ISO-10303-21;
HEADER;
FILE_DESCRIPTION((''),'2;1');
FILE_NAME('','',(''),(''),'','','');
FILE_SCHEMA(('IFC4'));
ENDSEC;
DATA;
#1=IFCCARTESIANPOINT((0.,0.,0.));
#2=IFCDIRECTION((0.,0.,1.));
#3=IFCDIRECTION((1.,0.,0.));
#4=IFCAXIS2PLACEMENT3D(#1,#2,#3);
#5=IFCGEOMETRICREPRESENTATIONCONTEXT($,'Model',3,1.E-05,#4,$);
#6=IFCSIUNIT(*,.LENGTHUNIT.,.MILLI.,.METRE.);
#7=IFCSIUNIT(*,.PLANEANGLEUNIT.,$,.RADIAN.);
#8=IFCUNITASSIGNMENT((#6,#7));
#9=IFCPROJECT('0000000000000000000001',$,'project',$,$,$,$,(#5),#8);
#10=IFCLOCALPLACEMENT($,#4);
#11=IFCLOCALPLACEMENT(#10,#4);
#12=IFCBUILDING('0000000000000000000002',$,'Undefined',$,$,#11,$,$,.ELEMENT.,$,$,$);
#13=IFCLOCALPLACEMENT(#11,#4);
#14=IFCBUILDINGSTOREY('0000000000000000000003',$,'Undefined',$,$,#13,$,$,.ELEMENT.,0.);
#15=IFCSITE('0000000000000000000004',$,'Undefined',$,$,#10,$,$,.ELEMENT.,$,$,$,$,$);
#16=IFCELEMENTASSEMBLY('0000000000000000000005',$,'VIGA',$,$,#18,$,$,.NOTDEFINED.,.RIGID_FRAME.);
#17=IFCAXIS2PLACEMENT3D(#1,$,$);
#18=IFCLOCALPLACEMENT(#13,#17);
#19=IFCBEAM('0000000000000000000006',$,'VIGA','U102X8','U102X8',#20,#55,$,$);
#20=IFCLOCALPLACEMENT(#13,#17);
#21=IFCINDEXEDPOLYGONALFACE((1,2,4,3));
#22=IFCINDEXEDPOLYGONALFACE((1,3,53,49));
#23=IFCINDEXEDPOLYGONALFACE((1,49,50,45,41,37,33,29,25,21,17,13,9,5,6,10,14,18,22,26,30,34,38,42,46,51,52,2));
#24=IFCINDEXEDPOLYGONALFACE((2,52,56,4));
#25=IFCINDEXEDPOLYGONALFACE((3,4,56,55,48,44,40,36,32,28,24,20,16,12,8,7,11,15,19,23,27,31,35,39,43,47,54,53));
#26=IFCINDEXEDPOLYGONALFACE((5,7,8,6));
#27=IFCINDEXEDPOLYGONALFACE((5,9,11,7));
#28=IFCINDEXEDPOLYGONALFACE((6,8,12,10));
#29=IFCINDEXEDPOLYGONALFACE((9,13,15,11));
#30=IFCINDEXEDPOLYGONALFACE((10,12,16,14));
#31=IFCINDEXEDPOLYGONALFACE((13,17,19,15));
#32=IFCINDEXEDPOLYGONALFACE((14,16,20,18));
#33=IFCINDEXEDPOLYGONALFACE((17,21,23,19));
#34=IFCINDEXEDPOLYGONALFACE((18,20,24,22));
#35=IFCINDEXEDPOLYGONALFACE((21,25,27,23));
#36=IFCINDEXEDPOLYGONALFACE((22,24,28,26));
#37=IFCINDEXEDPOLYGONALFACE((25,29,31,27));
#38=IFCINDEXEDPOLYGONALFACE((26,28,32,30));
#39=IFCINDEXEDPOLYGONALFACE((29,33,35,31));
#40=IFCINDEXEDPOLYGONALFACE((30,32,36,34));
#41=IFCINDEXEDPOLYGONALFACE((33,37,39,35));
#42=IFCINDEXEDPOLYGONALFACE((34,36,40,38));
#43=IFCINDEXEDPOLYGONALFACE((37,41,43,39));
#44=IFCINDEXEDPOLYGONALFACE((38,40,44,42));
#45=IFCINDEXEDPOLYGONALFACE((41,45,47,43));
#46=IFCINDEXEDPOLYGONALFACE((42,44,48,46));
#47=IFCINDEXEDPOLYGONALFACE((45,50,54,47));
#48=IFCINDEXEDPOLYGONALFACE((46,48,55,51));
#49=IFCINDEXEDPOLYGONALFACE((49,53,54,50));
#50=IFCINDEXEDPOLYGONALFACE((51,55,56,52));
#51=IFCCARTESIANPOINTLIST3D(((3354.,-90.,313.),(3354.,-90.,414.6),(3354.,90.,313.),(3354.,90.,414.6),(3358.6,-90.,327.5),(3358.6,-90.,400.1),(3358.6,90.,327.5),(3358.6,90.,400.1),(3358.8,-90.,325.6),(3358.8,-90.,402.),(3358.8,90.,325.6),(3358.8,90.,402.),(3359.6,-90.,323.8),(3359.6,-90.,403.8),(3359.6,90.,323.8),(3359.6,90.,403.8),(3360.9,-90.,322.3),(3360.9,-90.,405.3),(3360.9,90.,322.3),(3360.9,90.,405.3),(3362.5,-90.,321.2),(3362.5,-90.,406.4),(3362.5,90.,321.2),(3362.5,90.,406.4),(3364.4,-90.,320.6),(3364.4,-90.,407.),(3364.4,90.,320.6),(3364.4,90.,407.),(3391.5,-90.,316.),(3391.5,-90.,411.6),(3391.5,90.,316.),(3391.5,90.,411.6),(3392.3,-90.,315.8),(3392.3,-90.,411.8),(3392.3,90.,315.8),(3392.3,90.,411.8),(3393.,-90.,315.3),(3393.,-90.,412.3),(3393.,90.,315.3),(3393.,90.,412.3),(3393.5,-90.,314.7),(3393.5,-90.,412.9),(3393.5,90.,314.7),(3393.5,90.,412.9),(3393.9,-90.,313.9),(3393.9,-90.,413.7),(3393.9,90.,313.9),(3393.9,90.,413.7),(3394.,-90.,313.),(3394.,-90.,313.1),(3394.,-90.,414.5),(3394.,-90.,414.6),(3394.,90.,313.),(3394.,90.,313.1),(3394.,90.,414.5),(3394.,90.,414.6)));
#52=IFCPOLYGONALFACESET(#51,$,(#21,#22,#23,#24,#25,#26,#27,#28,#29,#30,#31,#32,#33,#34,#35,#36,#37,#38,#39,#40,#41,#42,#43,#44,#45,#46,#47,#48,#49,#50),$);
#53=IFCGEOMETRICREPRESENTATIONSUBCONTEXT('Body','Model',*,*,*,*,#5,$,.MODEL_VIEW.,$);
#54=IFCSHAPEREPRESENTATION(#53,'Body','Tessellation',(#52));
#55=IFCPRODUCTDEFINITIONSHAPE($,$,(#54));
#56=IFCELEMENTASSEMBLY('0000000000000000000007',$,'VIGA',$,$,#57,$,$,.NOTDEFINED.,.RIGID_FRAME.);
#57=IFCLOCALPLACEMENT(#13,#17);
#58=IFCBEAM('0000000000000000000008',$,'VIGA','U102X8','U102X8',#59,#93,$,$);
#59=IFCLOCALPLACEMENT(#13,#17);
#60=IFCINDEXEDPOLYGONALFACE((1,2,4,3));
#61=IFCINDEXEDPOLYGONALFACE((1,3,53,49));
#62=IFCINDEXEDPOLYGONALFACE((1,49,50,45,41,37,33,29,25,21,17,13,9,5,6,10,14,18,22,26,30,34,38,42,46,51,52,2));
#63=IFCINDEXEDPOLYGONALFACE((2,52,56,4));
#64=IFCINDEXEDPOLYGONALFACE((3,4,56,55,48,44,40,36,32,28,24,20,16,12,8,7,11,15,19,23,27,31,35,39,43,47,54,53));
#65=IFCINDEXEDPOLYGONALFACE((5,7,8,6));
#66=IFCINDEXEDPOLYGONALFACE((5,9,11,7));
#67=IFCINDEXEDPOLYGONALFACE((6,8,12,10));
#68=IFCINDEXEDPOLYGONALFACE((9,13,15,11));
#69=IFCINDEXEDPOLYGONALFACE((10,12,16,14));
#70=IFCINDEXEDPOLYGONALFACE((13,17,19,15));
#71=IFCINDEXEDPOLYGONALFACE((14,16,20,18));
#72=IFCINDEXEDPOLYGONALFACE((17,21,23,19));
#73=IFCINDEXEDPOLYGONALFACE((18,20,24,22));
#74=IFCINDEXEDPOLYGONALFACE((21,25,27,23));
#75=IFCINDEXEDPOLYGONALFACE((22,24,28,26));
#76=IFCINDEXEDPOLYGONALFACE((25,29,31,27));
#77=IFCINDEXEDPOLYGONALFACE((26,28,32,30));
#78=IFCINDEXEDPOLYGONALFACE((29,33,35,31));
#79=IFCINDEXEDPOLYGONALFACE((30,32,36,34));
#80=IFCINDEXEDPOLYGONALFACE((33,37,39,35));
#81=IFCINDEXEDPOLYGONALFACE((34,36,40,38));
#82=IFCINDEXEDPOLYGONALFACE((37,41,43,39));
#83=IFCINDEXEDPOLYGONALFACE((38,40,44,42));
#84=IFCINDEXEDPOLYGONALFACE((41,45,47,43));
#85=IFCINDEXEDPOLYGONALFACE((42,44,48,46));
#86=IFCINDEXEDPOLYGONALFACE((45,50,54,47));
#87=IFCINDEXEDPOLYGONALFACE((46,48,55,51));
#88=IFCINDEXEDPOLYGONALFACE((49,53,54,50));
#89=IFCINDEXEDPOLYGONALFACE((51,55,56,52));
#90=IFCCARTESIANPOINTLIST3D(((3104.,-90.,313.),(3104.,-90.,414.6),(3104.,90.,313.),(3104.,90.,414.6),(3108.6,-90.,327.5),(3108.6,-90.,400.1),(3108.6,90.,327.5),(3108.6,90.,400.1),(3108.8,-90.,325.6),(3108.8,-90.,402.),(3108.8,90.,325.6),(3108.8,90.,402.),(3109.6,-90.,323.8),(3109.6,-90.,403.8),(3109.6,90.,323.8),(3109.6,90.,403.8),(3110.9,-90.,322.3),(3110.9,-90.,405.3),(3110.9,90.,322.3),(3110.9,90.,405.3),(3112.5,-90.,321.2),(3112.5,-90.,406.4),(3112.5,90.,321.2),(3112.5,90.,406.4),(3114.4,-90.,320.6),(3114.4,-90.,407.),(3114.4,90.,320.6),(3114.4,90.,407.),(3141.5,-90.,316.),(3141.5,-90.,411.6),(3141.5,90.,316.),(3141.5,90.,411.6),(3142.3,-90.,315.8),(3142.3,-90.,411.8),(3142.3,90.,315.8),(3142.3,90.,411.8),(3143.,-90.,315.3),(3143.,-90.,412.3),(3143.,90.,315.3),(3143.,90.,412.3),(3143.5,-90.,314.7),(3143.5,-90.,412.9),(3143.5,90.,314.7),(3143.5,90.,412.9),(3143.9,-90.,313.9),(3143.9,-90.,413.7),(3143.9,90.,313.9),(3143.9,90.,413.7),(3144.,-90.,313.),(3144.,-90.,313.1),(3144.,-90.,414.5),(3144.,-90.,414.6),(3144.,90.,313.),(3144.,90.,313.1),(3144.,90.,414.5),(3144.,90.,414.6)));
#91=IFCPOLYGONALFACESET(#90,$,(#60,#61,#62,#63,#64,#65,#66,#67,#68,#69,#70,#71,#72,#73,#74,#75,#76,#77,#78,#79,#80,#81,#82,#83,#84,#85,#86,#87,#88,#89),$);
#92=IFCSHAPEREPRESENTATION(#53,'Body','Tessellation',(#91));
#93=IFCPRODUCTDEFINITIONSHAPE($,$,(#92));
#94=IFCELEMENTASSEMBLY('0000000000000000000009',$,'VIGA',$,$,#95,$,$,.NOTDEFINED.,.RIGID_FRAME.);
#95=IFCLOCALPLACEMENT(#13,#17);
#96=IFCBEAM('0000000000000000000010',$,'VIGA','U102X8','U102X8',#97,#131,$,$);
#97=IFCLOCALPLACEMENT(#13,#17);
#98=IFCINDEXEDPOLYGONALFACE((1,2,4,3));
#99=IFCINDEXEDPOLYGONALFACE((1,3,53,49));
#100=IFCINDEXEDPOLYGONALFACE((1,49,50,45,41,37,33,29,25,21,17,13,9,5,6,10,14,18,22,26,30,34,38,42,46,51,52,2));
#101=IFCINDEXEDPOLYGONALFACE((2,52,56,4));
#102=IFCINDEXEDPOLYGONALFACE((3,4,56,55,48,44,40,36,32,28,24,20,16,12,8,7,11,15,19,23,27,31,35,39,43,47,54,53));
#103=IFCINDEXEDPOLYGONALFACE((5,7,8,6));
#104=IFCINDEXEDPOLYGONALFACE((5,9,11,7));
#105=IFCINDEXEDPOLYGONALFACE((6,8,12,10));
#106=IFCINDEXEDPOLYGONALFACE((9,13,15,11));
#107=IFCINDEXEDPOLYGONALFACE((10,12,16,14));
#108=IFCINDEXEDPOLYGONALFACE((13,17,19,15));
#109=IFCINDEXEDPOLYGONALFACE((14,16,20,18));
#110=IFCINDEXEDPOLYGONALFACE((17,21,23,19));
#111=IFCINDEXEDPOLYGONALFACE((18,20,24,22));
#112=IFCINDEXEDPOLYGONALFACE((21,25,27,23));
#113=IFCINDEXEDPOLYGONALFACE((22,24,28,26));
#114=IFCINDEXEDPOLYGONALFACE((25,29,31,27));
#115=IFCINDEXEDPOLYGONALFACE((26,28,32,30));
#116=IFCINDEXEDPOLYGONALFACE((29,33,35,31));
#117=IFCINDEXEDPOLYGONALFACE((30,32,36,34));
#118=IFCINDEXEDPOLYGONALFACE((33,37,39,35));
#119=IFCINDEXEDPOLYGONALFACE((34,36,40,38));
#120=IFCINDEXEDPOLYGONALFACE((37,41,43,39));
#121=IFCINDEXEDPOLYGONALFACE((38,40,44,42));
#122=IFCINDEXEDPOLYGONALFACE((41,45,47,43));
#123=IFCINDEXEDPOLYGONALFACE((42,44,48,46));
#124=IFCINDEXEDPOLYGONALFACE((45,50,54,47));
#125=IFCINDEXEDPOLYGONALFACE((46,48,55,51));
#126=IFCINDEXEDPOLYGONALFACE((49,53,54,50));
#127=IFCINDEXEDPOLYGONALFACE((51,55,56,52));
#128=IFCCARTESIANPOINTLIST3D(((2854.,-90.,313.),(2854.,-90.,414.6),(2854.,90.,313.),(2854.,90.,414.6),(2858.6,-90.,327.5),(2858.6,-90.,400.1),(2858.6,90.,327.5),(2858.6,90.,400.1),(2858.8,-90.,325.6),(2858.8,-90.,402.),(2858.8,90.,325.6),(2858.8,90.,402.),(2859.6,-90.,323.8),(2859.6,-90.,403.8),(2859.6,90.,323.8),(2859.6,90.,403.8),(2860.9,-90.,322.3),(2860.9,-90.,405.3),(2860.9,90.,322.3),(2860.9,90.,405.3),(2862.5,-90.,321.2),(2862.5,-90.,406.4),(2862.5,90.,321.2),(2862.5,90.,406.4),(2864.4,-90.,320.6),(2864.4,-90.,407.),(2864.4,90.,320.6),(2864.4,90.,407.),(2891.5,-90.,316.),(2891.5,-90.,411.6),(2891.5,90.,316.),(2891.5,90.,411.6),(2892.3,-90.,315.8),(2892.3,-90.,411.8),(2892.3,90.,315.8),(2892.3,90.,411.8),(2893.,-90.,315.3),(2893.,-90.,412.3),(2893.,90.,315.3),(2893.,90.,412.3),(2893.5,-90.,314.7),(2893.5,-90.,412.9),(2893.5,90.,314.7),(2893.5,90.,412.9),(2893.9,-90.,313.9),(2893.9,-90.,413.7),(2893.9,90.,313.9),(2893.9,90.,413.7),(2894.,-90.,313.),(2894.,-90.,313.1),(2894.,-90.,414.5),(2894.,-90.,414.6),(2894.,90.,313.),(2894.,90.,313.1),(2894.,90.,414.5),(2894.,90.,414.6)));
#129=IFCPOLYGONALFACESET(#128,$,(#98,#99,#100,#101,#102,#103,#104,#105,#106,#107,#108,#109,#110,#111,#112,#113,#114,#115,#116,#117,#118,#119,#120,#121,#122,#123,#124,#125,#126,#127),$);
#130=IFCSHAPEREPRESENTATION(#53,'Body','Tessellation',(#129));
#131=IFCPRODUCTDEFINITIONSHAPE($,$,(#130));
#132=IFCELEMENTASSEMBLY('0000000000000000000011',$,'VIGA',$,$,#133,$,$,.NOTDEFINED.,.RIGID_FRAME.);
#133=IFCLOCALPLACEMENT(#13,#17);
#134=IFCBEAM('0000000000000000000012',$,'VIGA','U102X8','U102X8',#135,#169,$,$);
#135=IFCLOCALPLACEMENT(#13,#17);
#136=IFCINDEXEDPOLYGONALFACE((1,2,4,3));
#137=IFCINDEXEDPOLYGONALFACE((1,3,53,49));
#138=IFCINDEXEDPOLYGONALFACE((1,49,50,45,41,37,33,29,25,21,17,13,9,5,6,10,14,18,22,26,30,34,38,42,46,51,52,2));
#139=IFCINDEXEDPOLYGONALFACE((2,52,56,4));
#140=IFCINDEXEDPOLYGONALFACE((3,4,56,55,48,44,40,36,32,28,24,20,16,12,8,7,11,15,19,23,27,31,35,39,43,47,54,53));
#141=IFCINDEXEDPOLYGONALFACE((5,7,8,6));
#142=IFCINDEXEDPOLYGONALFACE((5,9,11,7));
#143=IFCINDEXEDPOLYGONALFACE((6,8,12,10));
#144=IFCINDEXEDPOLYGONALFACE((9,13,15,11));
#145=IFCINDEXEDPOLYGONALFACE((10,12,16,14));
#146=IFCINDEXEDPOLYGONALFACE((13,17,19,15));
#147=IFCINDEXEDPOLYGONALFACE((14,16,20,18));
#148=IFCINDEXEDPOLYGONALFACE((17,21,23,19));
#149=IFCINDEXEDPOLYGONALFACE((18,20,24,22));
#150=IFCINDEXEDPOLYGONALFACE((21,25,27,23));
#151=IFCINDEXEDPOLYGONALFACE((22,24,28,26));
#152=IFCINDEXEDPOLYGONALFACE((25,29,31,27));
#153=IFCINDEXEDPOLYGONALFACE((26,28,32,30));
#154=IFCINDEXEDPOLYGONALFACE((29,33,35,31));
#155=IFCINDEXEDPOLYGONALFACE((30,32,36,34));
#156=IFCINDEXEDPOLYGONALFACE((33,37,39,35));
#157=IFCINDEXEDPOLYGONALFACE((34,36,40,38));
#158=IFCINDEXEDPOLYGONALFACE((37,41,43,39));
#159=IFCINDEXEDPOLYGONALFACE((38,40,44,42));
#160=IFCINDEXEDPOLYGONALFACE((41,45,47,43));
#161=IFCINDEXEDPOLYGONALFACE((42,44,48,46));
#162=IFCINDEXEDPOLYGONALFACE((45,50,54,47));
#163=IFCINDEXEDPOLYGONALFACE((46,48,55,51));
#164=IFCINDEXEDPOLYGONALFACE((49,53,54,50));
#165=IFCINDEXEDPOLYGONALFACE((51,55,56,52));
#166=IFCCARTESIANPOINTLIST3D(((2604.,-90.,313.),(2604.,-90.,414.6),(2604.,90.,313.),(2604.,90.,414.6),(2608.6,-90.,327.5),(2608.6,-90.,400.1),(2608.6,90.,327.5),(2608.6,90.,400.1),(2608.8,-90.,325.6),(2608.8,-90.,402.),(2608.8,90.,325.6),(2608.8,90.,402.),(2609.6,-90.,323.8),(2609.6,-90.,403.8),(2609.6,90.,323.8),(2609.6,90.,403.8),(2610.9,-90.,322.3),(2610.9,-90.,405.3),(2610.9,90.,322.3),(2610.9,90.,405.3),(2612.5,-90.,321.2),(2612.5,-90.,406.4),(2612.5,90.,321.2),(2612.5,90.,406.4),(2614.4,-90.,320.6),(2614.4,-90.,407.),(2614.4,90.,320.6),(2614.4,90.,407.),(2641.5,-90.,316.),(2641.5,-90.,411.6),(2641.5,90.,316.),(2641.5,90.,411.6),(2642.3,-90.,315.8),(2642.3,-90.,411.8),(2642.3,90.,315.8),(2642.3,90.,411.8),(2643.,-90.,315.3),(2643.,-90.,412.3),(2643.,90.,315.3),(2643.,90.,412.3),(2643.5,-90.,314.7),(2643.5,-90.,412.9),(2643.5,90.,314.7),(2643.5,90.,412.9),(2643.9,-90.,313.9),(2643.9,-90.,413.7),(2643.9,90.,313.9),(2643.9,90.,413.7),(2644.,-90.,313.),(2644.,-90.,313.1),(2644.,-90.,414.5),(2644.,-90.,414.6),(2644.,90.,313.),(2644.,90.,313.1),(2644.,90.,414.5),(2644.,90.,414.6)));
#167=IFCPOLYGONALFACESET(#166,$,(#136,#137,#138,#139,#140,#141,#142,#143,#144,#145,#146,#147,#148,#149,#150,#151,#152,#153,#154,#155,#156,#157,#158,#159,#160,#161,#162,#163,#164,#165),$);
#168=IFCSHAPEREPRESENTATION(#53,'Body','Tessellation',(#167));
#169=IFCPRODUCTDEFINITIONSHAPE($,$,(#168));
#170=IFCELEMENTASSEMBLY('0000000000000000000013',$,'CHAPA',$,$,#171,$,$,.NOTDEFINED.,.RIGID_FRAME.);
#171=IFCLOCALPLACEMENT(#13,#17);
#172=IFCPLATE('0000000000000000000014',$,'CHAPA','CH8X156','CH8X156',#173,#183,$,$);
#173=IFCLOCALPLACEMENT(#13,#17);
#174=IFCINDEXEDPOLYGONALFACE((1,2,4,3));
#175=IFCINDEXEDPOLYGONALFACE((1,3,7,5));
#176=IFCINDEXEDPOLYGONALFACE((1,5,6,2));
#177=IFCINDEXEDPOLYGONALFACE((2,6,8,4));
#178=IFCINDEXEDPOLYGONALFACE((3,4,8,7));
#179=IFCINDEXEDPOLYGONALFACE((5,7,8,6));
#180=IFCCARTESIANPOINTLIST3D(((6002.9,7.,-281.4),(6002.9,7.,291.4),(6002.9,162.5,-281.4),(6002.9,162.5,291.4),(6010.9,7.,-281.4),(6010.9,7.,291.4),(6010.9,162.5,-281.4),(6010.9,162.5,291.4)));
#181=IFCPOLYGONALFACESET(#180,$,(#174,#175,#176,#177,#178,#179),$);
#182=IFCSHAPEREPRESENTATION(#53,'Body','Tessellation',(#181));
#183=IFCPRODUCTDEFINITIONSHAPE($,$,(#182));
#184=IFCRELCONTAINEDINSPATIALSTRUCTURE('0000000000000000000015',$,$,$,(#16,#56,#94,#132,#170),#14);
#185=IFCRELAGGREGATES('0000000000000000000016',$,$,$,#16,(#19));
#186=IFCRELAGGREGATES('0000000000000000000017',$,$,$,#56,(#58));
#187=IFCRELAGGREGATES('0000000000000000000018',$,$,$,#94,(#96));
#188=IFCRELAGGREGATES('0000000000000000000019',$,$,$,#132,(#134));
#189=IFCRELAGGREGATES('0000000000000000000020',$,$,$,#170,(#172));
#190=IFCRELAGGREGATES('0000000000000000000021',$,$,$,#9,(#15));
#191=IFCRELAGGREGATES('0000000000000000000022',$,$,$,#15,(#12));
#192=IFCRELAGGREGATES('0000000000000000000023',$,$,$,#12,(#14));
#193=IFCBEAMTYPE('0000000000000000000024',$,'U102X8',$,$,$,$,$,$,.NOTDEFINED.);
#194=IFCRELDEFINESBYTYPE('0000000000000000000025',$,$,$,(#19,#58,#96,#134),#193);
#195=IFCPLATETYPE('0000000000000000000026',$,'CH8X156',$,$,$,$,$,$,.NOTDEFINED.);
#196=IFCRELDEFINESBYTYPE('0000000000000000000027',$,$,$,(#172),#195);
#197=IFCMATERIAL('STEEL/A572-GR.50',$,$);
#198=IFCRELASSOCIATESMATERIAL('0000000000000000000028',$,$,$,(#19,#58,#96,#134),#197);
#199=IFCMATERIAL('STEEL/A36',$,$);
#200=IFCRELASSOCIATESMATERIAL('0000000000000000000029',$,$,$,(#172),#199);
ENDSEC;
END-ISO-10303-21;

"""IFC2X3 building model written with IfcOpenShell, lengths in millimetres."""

from ifc_helpers import new_model, si_unit, frame, origin_with_axes, origin_2d_with_axis, place, context, subcontext, project, spatial, polyline, u_section, outline, extrude, material, type_object, element, aggregate, save


model = new_model("IFC2X3")

# Units and contexts
model_context = context("Model", 3, precision=1e-05, world=origin_with_axes())
body_context = subcontext(model_context, "Body", "Model", "MODEL_VIEW")
ifc_project = project(units=[si_unit("LENGTHUNIT", "METRE", prefix="MILLI"), si_unit("PLANEANGLEUNIT", "RADIAN")], contexts=[model_context])

# Site, building, storey
site_placement = place(None, origin_with_axes())
site = spatial("IfcSite", under=ifc_project, at=site_placement, Name="Undefined", CompositionType="ELEMENT")
building_placement = place(site_placement, origin_with_axes())
building = spatial("IfcBuilding", under=site, at=building_placement, Name="Undefined", CompositionType="ELEMENT")
storey_placement = place(building_placement, origin_with_axes())
storey = spatial("IfcBuildingStorey", under=building, at=storey_placement, Name="Undefined", CompositionType="ELEMENT", Elevation=0.0)

# Element assemblies, beams
ifc_material_1 = material(Name="STEEL/A572-GR.50")
beam_type_1 = type_object("IfcBeamType", Name="U102X8", PredefinedType="NOTDEFINED")
assembly_1_placement = place(storey_placement, origin_with_axes())
assembly_1 = element("IfcElementAssembly", 1, at=assembly_1_placement, inside=storey, Name="VIGA", AssemblyPlace="NOTDEFINED", PredefinedType="RIGID_FRAME")
beam_1_placement = place(assembly_1_placement, frame((3374.0, -90.0, 363.8), z_axis=(0.0, 0.0, 1.0), x_axis=(0.0, 1.0, 0.0)))
beam_1 = element("IfcBeam", 2, at=beam_1_placement, type_object=beam_type_1, material=ifc_material_1, Name="VIGA", Description="U102X8", ObjectType="U102X8", context=body_context, shape_type="SweptSolid", body=[
    extrude(u_section(Depth=101.6, FlangeWidth=40.0, WebThickness=4.6, FlangeThickness=6.0, FilletRadius=7.0, EdgeRadius=3.0, FlangeSlope=0.16839, at=origin_2d_with_axis()), frame((180.0, 0.0, 0.0), z_axis=(-1.0, 0.0, 0.0), x_axis=(0.0, -1.0, 0.0)), (0.0, 0.0, 1.0), 180.0),
])
aggregate(assembly_1, [beam_1])
assembly_2_placement = place(storey_placement, origin_with_axes())
assembly_2 = element("IfcElementAssembly", 3, at=assembly_2_placement, inside=storey, Name="VIGA", AssemblyPlace="NOTDEFINED", PredefinedType="RIGID_FRAME")
beam_2_placement = place(assembly_2_placement, frame((3124.0, -90.0, 363.8), z_axis=(0.0, 0.0, 1.0), x_axis=(0.0, 1.0, 0.0)))
beam_2 = element("IfcBeam", 4, at=beam_2_placement, type_object=beam_type_1, material=ifc_material_1, Name="VIGA", Description="U102X8", ObjectType="U102X8", context=body_context, shape_type="SweptSolid", body=[
    extrude(u_section(Depth=101.6, FlangeWidth=40.0, WebThickness=4.6, FlangeThickness=6.0, FilletRadius=7.0, EdgeRadius=3.0, FlangeSlope=0.16839, at=origin_2d_with_axis()), frame((180.0, 0.0, 0.0), z_axis=(-1.0, 0.0, 0.0), x_axis=(0.0, -1.0, 0.0)), (0.0, 0.0, 1.0), 180.0),
])
aggregate(assembly_2, [beam_2])
assembly_3_placement = place(storey_placement, origin_with_axes())
assembly_3 = element("IfcElementAssembly", 5, at=assembly_3_placement, inside=storey, Name="VIGA", AssemblyPlace="NOTDEFINED", PredefinedType="RIGID_FRAME")
beam_3_placement = place(assembly_3_placement, frame((2874.0, -90.0, 363.8), z_axis=(0.0, 0.0, 1.0), x_axis=(0.0, 1.0, 0.0)))
beam_3 = element("IfcBeam", 6, at=beam_3_placement, type_object=beam_type_1, material=ifc_material_1, Name="VIGA", Description="U102X8", ObjectType="U102X8", context=body_context, shape_type="SweptSolid", body=[
    extrude(u_section(Depth=101.6, FlangeWidth=40.0, WebThickness=4.6, FlangeThickness=6.0, FilletRadius=7.0, EdgeRadius=3.0, FlangeSlope=0.16839, at=origin_2d_with_axis()), frame((180.0, 0.0, 0.0), z_axis=(-1.0, 0.0, 0.0), x_axis=(0.0, -1.0, 0.0)), (0.0, 0.0, 1.0), 180.0),
])
aggregate(assembly_3, [beam_3])
assembly_4_placement = place(storey_placement, origin_with_axes())
assembly_4 = element("IfcElementAssembly", 7, at=assembly_4_placement, inside=storey, Name="VIGA", AssemblyPlace="NOTDEFINED", PredefinedType="RIGID_FRAME")
beam_4_placement = place(assembly_4_placement, frame((2624.0, -90.0, 363.8), z_axis=(0.0, 0.0, 1.0), x_axis=(0.0, 1.0, 0.0)))
beam_4 = element("IfcBeam", 8, at=beam_4_placement, type_object=beam_type_1, material=ifc_material_1, Name="VIGA", Description="U102X8", ObjectType="U102X8", context=body_context, shape_type="SweptSolid", body=[
    extrude(u_section(Depth=101.6, FlangeWidth=40.0, WebThickness=4.6, FlangeThickness=6.0, FilletRadius=7.0, EdgeRadius=3.0, FlangeSlope=0.16839, at=origin_2d_with_axis()), frame((180.0, 0.0, 0.0), z_axis=(-1.0, 0.0, 0.0), x_axis=(0.0, -1.0, 0.0)), (0.0, 0.0, 1.0), 180.0),
])
aggregate(assembly_4, [beam_4])

# Element assembly, plate
assembly_5_placement = place(storey_placement, origin_with_axes())
assembly_5 = element("IfcElementAssembly", 9, at=assembly_5_placement, inside=storey, Name="CHAPA", AssemblyPlace="NOTDEFINED", PredefinedType="RIGID_FRAME")
ifc_material_2 = material(Name="STEEL/A36")
plate_type = type_object("IfcPlateType", Name="CH8X156", PredefinedType="NOTDEFINED")
plate_placement = place(assembly_5_placement, frame((6006.9, 162.5, 291.4), z_axis=(1.0, 0.0, 0.0), x_axis=(0.0, -1.0, 0.0)))
plate = element("IfcPlate", 10, at=plate_placement, type_object=plate_type, material=ifc_material_2, Name="CHAPA", Description="CH8X156", ObjectType="CH8X156", context=body_context, shape_type="SweptSolid", body=[
    extrude(outline(polyline([(0.0, 0.0), (155.5, 0.0), (155.5, 572.8), (0.0, 572.8), (0.0, 0.0)])), frame((0.0, 0.0, -4.0), z_axis=(0.0, 0.0, 1.0), x_axis=(1.0, 0.0, 0.0)), (0.0, 0.0, 1.0), 8.0),
])
aggregate(assembly_5, [plate])

save(model, "model.ifc")
